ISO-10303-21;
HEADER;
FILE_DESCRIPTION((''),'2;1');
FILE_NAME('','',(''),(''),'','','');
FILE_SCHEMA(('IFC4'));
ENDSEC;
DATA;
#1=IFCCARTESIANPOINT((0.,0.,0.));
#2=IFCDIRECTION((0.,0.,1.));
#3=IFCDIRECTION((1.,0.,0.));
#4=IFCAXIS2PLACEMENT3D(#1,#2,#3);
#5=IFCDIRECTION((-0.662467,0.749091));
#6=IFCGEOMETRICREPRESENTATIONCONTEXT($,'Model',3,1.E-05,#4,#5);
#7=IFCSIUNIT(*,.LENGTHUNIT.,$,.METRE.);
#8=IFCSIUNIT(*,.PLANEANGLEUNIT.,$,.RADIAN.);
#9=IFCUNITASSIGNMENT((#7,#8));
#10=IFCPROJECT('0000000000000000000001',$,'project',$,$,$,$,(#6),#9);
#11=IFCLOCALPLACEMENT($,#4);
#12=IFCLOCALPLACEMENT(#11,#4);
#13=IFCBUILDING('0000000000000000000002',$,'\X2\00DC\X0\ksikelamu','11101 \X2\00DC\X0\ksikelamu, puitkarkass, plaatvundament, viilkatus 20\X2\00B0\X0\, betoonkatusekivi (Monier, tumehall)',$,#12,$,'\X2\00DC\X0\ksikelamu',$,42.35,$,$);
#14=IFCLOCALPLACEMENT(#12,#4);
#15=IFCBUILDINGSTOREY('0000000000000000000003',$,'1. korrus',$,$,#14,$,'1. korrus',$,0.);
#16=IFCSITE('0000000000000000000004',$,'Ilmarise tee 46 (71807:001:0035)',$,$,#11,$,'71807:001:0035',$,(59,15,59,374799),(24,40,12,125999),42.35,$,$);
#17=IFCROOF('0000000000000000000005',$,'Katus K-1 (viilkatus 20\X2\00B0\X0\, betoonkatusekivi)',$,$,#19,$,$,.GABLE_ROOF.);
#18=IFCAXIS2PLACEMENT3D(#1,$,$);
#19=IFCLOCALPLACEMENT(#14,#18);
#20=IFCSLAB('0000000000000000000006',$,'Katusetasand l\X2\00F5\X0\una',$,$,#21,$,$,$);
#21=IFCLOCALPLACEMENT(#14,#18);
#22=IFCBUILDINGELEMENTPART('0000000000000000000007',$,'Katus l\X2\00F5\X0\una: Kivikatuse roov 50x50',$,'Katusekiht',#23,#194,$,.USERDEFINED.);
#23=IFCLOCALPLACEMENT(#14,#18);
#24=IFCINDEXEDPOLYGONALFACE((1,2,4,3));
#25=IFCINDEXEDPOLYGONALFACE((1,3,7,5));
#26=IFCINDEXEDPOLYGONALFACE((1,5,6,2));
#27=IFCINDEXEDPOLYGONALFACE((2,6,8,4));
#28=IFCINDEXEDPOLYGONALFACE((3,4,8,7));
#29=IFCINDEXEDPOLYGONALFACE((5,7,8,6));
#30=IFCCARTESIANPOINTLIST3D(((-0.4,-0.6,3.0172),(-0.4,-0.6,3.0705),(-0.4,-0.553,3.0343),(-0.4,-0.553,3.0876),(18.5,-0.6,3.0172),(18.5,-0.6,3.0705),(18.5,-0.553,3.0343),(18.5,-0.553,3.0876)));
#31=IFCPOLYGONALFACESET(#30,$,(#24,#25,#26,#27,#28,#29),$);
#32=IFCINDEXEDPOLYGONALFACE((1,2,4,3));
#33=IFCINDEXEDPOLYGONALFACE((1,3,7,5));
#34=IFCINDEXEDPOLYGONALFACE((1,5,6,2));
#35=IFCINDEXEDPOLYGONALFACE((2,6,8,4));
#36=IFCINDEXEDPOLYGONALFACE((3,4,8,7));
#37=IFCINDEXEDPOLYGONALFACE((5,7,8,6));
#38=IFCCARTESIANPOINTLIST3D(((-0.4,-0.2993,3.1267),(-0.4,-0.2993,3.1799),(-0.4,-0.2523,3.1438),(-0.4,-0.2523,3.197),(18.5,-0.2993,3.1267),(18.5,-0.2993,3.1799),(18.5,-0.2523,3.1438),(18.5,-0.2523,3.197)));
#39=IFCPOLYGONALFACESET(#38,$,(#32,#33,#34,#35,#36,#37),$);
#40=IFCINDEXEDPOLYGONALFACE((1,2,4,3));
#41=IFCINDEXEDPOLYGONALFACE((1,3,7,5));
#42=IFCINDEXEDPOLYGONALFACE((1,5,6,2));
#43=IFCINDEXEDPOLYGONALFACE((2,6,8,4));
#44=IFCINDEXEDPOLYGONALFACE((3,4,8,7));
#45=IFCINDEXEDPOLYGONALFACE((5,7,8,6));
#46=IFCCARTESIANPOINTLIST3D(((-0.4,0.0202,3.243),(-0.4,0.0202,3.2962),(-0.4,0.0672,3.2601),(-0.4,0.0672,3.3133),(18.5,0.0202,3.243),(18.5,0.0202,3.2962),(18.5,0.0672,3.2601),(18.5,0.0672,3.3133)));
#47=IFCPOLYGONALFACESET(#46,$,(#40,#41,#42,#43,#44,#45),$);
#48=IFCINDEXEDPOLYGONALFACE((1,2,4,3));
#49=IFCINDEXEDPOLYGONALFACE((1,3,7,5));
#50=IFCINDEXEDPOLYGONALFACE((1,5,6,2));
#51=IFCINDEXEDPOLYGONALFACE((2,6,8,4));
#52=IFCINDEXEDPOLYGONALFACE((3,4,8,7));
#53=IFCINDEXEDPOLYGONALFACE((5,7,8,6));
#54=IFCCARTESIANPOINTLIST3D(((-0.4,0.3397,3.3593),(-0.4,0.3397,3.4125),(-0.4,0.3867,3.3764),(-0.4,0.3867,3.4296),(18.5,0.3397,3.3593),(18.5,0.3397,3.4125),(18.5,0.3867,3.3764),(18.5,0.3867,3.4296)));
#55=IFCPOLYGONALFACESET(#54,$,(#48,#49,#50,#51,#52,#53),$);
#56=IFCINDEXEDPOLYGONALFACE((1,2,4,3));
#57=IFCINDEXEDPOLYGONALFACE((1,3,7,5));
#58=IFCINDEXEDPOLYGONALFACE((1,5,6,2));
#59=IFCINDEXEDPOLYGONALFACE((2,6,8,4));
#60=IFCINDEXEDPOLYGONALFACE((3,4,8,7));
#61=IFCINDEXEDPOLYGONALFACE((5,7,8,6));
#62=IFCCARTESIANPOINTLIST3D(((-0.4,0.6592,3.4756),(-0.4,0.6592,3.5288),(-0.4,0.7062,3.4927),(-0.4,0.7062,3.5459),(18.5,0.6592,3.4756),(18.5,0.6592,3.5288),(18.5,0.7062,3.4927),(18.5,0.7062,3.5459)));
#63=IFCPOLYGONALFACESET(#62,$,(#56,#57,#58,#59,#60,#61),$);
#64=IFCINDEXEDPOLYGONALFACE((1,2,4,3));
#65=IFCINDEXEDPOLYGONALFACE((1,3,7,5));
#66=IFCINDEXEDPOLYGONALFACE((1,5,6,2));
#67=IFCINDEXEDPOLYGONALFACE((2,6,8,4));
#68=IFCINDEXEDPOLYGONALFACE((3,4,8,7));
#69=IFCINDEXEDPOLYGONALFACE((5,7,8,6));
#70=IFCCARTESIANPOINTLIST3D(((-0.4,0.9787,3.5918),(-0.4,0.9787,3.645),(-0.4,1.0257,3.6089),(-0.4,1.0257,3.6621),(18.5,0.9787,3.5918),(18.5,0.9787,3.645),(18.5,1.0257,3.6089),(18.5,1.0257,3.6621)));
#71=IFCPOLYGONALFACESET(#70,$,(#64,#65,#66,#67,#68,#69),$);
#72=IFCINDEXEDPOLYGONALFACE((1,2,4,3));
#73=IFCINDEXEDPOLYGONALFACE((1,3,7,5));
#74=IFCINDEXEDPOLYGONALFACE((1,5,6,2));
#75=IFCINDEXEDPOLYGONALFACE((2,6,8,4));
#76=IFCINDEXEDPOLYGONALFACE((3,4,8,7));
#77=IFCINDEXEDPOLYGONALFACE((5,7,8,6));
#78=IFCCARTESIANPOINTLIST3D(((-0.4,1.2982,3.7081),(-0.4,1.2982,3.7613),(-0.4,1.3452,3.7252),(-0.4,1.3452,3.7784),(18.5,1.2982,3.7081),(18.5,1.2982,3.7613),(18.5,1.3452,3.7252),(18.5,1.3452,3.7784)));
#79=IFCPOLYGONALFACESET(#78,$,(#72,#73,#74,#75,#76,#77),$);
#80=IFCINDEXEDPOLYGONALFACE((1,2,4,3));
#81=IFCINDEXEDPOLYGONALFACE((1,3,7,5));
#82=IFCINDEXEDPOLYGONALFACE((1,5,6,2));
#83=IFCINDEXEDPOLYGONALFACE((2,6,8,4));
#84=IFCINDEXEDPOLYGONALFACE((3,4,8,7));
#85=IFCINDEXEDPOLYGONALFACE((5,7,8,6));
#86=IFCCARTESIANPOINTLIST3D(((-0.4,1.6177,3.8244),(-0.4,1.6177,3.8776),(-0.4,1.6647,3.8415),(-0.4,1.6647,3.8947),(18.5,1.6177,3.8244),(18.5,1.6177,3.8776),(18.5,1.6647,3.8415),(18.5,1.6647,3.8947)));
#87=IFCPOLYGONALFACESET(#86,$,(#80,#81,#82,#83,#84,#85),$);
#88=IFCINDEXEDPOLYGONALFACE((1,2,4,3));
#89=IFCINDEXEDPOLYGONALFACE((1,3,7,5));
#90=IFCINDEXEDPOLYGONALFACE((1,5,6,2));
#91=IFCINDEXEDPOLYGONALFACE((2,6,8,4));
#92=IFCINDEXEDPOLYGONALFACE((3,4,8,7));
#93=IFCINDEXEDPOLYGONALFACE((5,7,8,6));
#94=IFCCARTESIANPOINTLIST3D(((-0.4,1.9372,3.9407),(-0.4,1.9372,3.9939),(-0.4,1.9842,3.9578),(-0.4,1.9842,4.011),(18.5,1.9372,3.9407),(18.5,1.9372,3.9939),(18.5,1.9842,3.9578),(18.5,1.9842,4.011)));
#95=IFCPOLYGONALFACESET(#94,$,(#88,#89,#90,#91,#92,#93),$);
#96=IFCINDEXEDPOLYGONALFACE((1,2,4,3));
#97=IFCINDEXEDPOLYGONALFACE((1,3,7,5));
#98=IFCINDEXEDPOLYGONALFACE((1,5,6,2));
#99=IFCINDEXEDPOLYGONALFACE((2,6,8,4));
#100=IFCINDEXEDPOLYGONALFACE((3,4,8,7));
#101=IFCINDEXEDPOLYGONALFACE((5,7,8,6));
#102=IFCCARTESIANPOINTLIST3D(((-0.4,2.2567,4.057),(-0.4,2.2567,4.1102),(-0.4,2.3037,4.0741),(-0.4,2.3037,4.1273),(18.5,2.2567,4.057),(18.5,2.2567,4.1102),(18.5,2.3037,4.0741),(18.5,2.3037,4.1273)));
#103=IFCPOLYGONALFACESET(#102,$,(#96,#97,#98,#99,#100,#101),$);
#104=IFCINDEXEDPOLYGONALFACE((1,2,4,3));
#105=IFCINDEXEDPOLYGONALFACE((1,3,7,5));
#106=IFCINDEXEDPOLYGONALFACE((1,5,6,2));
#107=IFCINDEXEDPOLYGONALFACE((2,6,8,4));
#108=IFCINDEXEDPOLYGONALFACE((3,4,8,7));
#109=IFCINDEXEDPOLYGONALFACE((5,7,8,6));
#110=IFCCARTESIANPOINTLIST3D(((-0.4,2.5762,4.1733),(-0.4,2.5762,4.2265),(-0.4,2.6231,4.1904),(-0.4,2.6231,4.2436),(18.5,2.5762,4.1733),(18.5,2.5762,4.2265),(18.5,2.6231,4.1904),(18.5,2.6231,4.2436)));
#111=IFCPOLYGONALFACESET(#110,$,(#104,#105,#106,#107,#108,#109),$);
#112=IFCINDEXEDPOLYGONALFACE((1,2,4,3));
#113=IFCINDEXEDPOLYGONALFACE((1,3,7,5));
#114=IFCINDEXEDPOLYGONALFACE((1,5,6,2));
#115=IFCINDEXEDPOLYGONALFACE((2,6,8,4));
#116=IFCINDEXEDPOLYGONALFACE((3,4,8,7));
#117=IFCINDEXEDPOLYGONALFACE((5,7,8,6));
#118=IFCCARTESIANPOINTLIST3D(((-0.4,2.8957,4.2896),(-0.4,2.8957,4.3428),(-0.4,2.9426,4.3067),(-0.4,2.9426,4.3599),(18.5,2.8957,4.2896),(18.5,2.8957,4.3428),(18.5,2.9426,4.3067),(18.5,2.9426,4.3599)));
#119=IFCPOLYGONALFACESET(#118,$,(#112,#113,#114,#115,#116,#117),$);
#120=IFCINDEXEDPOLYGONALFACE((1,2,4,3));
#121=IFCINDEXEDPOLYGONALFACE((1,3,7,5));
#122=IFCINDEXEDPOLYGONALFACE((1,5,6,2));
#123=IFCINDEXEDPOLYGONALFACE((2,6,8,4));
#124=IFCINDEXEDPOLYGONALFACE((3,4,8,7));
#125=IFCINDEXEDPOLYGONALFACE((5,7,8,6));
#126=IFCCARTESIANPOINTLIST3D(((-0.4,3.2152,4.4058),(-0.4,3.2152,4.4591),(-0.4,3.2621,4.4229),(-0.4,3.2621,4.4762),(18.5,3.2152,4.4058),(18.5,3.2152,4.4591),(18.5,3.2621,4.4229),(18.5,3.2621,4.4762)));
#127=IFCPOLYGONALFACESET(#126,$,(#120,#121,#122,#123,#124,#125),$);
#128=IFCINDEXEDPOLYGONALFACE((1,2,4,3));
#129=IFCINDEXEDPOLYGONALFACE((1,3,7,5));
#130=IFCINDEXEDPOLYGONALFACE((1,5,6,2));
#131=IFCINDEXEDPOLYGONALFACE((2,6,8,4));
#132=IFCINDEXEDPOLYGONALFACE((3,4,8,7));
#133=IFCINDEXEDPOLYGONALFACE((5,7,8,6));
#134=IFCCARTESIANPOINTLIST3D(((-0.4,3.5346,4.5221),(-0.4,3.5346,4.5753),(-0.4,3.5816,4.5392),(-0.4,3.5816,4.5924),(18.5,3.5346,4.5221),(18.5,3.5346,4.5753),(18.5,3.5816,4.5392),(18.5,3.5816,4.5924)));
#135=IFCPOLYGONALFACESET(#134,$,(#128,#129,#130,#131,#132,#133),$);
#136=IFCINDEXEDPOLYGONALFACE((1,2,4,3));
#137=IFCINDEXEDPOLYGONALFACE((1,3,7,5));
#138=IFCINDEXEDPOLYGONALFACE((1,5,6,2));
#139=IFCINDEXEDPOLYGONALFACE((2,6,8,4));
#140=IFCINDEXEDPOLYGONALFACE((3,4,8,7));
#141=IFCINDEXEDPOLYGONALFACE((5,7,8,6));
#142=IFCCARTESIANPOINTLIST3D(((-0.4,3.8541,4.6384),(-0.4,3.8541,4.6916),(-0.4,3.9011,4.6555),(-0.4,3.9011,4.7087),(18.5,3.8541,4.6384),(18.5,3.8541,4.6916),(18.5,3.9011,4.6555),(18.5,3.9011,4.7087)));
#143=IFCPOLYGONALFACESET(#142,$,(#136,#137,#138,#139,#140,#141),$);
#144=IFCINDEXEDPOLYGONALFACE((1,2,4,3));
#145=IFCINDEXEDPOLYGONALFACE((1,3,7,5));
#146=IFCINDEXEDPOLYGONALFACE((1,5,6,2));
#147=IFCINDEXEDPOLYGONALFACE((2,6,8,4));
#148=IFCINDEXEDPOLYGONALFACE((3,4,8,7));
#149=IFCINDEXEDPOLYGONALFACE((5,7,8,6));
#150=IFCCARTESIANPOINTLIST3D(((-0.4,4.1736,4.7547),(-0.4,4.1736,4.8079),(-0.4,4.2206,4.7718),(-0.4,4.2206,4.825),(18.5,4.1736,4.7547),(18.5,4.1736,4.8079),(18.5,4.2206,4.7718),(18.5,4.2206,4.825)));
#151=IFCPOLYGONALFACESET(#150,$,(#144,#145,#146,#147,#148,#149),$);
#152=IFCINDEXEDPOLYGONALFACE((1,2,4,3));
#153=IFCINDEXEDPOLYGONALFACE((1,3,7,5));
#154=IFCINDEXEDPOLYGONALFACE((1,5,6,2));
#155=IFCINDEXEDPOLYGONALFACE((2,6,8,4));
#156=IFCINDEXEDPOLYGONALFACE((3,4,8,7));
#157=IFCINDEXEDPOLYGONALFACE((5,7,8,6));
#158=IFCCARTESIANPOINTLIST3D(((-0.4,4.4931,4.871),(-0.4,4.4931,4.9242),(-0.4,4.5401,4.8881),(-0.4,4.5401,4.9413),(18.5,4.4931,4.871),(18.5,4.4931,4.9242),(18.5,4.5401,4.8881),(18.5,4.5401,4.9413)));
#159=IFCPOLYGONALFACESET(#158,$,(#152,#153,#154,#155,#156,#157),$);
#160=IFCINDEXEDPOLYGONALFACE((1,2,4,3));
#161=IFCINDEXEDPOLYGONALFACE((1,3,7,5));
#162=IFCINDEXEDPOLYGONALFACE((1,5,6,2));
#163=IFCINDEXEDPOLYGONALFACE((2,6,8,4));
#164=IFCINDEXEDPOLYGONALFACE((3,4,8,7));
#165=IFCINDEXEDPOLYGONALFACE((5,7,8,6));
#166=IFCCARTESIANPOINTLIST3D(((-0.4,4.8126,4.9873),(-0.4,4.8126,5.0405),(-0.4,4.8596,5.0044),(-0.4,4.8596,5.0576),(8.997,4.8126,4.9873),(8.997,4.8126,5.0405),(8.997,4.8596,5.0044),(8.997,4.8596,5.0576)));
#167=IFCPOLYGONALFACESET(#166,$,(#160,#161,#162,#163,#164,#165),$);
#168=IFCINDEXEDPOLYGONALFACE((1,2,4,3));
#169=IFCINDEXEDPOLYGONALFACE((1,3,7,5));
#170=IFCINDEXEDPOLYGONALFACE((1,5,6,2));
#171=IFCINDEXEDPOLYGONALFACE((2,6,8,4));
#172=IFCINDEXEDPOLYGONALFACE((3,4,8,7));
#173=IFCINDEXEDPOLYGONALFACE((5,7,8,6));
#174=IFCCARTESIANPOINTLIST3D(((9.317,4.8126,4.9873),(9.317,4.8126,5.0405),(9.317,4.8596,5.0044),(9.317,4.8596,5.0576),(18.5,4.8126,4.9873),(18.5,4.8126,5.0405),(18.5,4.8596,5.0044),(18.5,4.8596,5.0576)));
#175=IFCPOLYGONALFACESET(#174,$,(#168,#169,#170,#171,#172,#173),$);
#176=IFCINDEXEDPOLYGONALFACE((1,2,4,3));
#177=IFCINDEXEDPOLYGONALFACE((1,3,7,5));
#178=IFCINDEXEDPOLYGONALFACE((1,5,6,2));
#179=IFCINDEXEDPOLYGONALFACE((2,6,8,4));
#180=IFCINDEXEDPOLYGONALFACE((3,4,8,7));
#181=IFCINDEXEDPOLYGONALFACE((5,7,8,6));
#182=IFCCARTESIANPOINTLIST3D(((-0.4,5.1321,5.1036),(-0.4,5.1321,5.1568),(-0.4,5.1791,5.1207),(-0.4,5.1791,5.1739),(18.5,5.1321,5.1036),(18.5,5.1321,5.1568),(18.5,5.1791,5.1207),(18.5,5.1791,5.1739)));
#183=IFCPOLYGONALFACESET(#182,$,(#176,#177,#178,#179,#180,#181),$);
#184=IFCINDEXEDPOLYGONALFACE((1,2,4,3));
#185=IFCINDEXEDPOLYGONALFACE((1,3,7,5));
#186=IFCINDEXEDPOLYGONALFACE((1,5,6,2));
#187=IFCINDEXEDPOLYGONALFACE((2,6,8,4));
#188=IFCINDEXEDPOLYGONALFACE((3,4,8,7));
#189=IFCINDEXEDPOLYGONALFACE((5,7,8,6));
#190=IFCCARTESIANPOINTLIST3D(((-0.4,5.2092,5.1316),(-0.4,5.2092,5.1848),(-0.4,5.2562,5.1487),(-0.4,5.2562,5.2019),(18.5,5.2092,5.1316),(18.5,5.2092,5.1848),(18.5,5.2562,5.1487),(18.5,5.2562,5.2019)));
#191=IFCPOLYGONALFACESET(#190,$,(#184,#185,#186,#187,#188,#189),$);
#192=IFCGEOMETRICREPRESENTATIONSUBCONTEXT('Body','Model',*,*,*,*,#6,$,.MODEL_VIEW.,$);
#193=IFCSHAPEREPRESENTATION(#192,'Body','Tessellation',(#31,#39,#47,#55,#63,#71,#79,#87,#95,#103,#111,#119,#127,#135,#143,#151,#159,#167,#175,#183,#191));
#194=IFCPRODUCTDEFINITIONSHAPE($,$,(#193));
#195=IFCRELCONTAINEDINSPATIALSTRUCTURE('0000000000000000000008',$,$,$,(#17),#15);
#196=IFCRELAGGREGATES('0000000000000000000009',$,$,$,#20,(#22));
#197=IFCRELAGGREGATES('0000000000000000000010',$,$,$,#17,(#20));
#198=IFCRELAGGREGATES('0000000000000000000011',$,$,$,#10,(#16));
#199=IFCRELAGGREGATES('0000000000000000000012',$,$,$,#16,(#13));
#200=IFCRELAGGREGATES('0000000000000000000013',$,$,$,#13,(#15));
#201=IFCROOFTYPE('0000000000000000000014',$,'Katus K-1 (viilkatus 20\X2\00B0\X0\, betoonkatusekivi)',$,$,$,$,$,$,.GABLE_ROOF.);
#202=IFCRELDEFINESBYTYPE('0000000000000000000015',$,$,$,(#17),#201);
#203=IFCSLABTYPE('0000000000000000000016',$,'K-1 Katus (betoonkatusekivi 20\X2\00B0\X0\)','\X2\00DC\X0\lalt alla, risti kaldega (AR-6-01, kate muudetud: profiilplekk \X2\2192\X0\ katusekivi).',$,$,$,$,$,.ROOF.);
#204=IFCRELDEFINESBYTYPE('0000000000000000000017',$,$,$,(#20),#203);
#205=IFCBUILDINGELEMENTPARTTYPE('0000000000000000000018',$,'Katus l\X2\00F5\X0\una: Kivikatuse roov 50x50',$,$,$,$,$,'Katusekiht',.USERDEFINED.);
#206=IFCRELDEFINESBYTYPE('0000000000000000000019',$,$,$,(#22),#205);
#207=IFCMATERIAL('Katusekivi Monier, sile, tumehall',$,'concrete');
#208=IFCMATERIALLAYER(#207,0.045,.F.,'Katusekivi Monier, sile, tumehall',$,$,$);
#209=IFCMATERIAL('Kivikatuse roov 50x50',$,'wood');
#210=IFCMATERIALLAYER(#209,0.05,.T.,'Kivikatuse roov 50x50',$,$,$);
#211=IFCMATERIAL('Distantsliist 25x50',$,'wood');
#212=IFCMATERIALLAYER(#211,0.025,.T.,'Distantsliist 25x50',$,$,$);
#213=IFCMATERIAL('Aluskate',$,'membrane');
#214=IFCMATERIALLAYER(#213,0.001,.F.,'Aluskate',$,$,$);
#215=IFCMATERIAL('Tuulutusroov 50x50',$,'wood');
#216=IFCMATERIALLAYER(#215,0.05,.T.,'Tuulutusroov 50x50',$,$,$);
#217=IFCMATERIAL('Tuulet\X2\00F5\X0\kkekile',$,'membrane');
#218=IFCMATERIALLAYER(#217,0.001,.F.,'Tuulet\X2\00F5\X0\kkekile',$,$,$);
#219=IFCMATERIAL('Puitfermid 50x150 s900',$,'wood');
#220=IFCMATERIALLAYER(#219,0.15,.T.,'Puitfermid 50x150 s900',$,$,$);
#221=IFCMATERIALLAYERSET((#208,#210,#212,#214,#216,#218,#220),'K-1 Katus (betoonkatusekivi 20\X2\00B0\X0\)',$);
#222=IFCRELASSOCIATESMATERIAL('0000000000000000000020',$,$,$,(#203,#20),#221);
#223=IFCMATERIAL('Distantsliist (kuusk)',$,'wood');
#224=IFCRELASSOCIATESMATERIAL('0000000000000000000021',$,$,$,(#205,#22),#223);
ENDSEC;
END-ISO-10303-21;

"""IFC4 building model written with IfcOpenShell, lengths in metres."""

from ifc_helpers import new_model, si_unit, direction, frame, origin_with_axes, place, context, subcontext, project, spatial, indexed_curve, outline, extrude, material, layer, layer_set, layer_usage, type_object, element, aggregate, save


model = new_model("IFC4")

# Units and contexts
model_context = context("Model", 3, precision=1e-05, world=origin_with_axes(), true_north=direction((-0.662467, 0.749091)))
body_context = subcontext(model_context, "Body", "Model", "MODEL_VIEW")
ifc_project = project(units=[si_unit("LENGTHUNIT", "METRE"), si_unit("PLANEANGLEUNIT", "RADIAN")], contexts=[model_context])

# Site, building, storey
site_placement = place(None, origin_with_axes())
site = spatial("IfcSite", under=ifc_project, at=site_placement, Name="Ilmarise tee 46 (71807:001:0035)", LongName="71807:001:0035", RefLatitude=(59, 15, 59, 374799), RefLongitude=(24, 40, 12, 125999), RefElevation=42.35)
building_placement = place(site_placement, origin_with_axes())
building = spatial("IfcBuilding", under=site, at=building_placement, Name="Üksikelamu", Description="11101 Üksikelamu, puitkarkass, plaatvundament, viilkatus 20°, betoonkatusekivi (Monier, tumehall)", LongName="Üksikelamu", ElevationOfRefHeight=42.35)
storey_placement = place(building_placement, origin_with_axes())
storey = spatial("IfcBuildingStorey", under=building, at=storey_placement, Name="1. korrus", LongName="1. korrus", Elevation=0.0)

# Roof
roof_type = type_object("IfcRoofType", Name="Katus K-1 (viilkatus 20°, betoonkatusekivi)", PredefinedType="GABLE_ROOF")
roof_placement = place(storey_placement, origin_with_axes())
roof = element("IfcRoof", 1, at=roof_placement, inside=storey, type_object=roof_type, Name="Katus K-1 (viilkatus 20°, betoonkatusekivi)", PredefinedType="GABLE_ROOF")

# Slab, building element part
ifc_material_1 = material(Name="Katusekivi Monier, sile, tumehall", Category="concrete")
ifc_layer_1 = layer(ifc_material_1, 0.045, ventilated=False, Name="Katusekivi Monier, sile, tumehall")
ifc_material_2 = material(Name="Kivikatuse roov 50x50", Category="wood")
ifc_layer_2 = layer(ifc_material_2, 0.05, ventilated=True, Name="Kivikatuse roov 50x50")
ifc_material_3 = material(Name="Distantsliist 25x50", Category="wood")
ifc_layer_3 = layer(ifc_material_3, 0.025, ventilated=True, Name="Distantsliist 25x50")
ifc_material_4 = material(Name="Aluskate", Category="membrane")
ifc_layer_4 = layer(ifc_material_4, 0.001, ventilated=False, Name="Aluskate")
ifc_material_5 = material(Name="Tuulutusroov 50x50", Category="wood")
ifc_layer_5 = layer(ifc_material_5, 0.05, ventilated=True, Name="Tuulutusroov 50x50")
ifc_material_6 = material(Name="Tuuletõkkekile", Category="membrane")
ifc_layer_6 = layer(ifc_material_6, 0.001, ventilated=False, Name="Tuuletõkkekile")
ifc_material_7 = material(Name="Puitfermid 50x150 s900", Category="wood")
ifc_layer_7 = layer(ifc_material_7, 0.15, ventilated=True, Name="Puitfermid 50x150 s900")
ifc_layer_set = layer_set([ifc_layer_1, ifc_layer_2, ifc_layer_3, ifc_layer_4, ifc_layer_5, ifc_layer_6, ifc_layer_7], Name="K-1 Katus (betoonkatusekivi 20°)")
ifc_layer_usage_1 = layer_usage(ifc_layer_set, "AXIS3", "POSITIVE", 0.0)
slab_type = type_object("IfcSlabType", Name="K-1 Katus (betoonkatusekivi 20°)", Description="Ülalt alla, risti kaldega (AR-6-01, kate muudetud: profiilplekk → katusekivi).", PredefinedType="ROOF", material=ifc_layer_set)
slab_1_placement = place(roof_placement, origin_with_axes())
slab_1 = element("IfcSlab", 2, at=slab_1_placement, type_object=slab_type, material=ifc_layer_usage_1, Name="Katusetasand lõuna")
ifc_material_8 = material(Name="Distantsliist (kuusk)", Category="wood")
building_element_part_type_1 = type_object("IfcBuildingElementPartType", Name="Katus lõuna: Kivikatuse roov 50x50", ElementType="Katusekiht", PredefinedType="USERDEFINED", material=ifc_material_8)
building_element_part_1_placement = place(slab_1_placement, origin_with_axes())
building_element_part_1 = element("IfcBuildingElementPart", 3, at=building_element_part_1_placement, type_object=building_element_part_type_1, material=ifc_material_8, Name="Katus lõuna: Kivikatuse roov 50x50", ObjectType="Katusekiht", PredefinedType="USERDEFINED", context=body_context, shape_type="SweptSolid", body=[
    extrude(outline(indexed_curve([(-0.6, 3.0172), (-0.553, 3.0343), (-0.553, 3.0876), (-0.6, 3.0705), (-0.6, 3.0172)], self_intersect=False)), frame((-0.4, 0.0, 0.0), z_axis=(1.0, 0.0, 0.0), x_axis=(0.0, 1.0, 0.0)), (0.0, 0.0, 1.0), 18.9),
    extrude(outline(indexed_curve([(-0.2993, 3.1267), (-0.2523, 3.1438), (-0.2523, 3.197), (-0.2993, 3.1799), (-0.2993, 3.1267)], self_intersect=False)), frame((-0.4, 0.0, 0.0), z_axis=(1.0, 0.0, 0.0), x_axis=(0.0, 1.0, 0.0)), (0.0, 0.0, 1.0), 18.9),
    extrude(outline(indexed_curve([(0.0202, 3.243), (0.0672, 3.2601), (0.0672, 3.3133), (0.0202, 3.2962), (0.0202, 3.243)], self_intersect=False)), frame((-0.4, 0.0, 0.0), z_axis=(1.0, 0.0, 0.0), x_axis=(0.0, 1.0, 0.0)), (0.0, 0.0, 1.0), 18.9),
    extrude(outline(indexed_curve([(0.3397, 3.3593), (0.3867, 3.3764), (0.3867, 3.4296), (0.3397, 3.4125), (0.3397, 3.3593)], self_intersect=False)), frame((-0.4, 0.0, 0.0), z_axis=(1.0, 0.0, 0.0), x_axis=(0.0, 1.0, 0.0)), (0.0, 0.0, 1.0), 18.9),
    extrude(outline(indexed_curve([(0.6592, 3.4756), (0.7062, 3.4927), (0.7062, 3.5459), (0.6592, 3.5288), (0.6592, 3.4756)], self_intersect=False)), frame((-0.4, 0.0, 0.0), z_axis=(1.0, 0.0, 0.0), x_axis=(0.0, 1.0, 0.0)), (0.0, 0.0, 1.0), 18.9),
    extrude(outline(indexed_curve([(0.9787, 3.5918), (1.0257, 3.6089), (1.0257, 3.6621), (0.9787, 3.645), (0.9787, 3.5918)], self_intersect=False)), frame((-0.4, 0.0, 0.0), z_axis=(1.0, 0.0, 0.0), x_axis=(0.0, 1.0, 0.0)), (0.0, 0.0, 1.0), 18.9),
    extrude(outline(indexed_curve([(1.2982, 3.7081), (1.3452, 3.7252), (1.3452, 3.7784), (1.2982, 3.7613), (1.2982, 3.7081)], self_intersect=False)), frame((-0.4, 0.0, 0.0), z_axis=(1.0, 0.0, 0.0), x_axis=(0.0, 1.0, 0.0)), (0.0, 0.0, 1.0), 18.9),
    extrude(outline(indexed_curve([(1.6177, 3.8244), (1.6647, 3.8415), (1.6647, 3.8947), (1.6177, 3.8776), (1.6177, 3.8244)], self_intersect=False)), frame((-0.4, 0.0, 0.0), z_axis=(1.0, 0.0, 0.0), x_axis=(0.0, 1.0, 0.0)), (0.0, 0.0, 1.0), 18.9),
    extrude(outline(indexed_curve([(1.9372, 3.9407), (1.9842, 3.9578), (1.9842, 4.011), (1.9372, 3.9939), (1.9372, 3.9407)], self_intersect=False)), frame((-0.4, 0.0, 0.0), z_axis=(1.0, 0.0, 0.0), x_axis=(0.0, 1.0, 0.0)), (0.0, 0.0, 1.0), 18.9),
    extrude(outline(indexed_curve([(2.2567, 4.057), (2.3037, 4.0741), (2.3037, 4.1273), (2.2567, 4.1102), (2.2567, 4.057)], self_intersect=False)), frame((-0.4, 0.0, 0.0), z_axis=(1.0, 0.0, 0.0), x_axis=(0.0, 1.0, 0.0)), (0.0, 0.0, 1.0), 18.9),
    extrude(outline(indexed_curve([(2.5762, 4.1733), (2.6231, 4.1904), (2.6231, 4.2436), (2.5762, 4.2265), (2.5762, 4.1733)], self_intersect=False)), frame((-0.4, 0.0, 0.0), z_axis=(1.0, 0.0, 0.0), x_axis=(0.0, 1.0, 0.0)), (0.0, 0.0, 1.0), 18.9),
    extrude(outline(indexed_curve([(2.8957, 4.2896), (2.9426, 4.3067), (2.9426, 4.3599), (2.8957, 4.3428), (2.8957, 4.2896)], self_intersect=False)), frame((-0.4, 0.0, 0.0), z_axis=(1.0, 0.0, 0.0), x_axis=(0.0, 1.0, 0.0)), (0.0, 0.0, 1.0), 18.9),
    extrude(outline(indexed_curve([(3.2152, 4.4058), (3.2621, 4.4229), (3.2621, 4.4762), (3.2152, 4.4591), (3.2152, 4.4058)], self_intersect=False)), frame((-0.4, 0.0, 0.0), z_axis=(1.0, 0.0, 0.0), x_axis=(0.0, 1.0, 0.0)), (0.0, 0.0, 1.0), 18.9),
    extrude(outline(indexed_curve([(3.5346, 4.5221), (3.5816, 4.5392), (3.5816, 4.5924), (3.5346, 4.5753), (3.5346, 4.5221)], self_intersect=False)), frame((-0.4, 0.0, 0.0), z_axis=(1.0, 0.0, 0.0), x_axis=(0.0, 1.0, 0.0)), (0.0, 0.0, 1.0), 18.9),
    extrude(outline(indexed_curve([(3.8541, 4.6384), (3.9011, 4.6555), (3.9011, 4.7087), (3.8541, 4.6916), (3.8541, 4.6384)], self_intersect=False)), frame((-0.4, 0.0, 0.0), z_axis=(1.0, 0.0, 0.0), x_axis=(0.0, 1.0, 0.0)), (0.0, 0.0, 1.0), 18.9),
    extrude(outline(indexed_curve([(4.1736, 4.7547), (4.2206, 4.7718), (4.2206, 4.825), (4.1736, 4.8079), (4.1736, 4.7547)], self_intersect=False)), frame((-0.4, 0.0, 0.0), z_axis=(1.0, 0.0, 0.0), x_axis=(0.0, 1.0, 0.0)), (0.0, 0.0, 1.0), 18.9),
    extrude(outline(indexed_curve([(4.4931, 4.871), (4.5401, 4.8881), (4.5401, 4.9413), (4.4931, 4.9242), (4.4931, 4.871)], self_intersect=False)), frame((-0.4, 0.0, 0.0), z_axis=(1.0, 0.0, 0.0), x_axis=(0.0, 1.0, 0.0)), (0.0, 0.0, 1.0), 18.9),
    extrude(outline(indexed_curve([(4.8126, 4.9873), (4.8596, 5.0044), (4.8596, 5.0576), (4.8126, 5.0405), (4.8126, 4.9873)], self_intersect=False)), frame((-0.4, 0.0, 0.0), z_axis=(1.0, 0.0, 0.0), x_axis=(0.0, 1.0, 0.0)), (0.0, 0.0, 1.0), 9.397),
    extrude(outline(indexed_curve([(4.8126, 4.9873), (4.8596, 5.0044), (4.8596, 5.0576), (4.8126, 5.0405), (4.8126, 4.9873)], self_intersect=False)), frame((9.317, 0.0, 0.0), z_axis=(1.0, 0.0, 0.0), x_axis=(0.0, 1.0, 0.0)), (0.0, 0.0, 1.0), 9.183),
    extrude(outline(indexed_curve([(5.1321, 5.1036), (5.1791, 5.1207), (5.1791, 5.1739), (5.1321, 5.1568), (5.1321, 5.1036)], self_intersect=False)), frame((-0.4, 0.0, 0.0), z_axis=(1.0, 0.0, 0.0), x_axis=(0.0, 1.0, 0.0)), (0.0, 0.0, 1.0), 18.9),
    extrude(outline(indexed_curve([(5.2092, 5.1316), (5.2562, 5.1487), (5.2562, 5.2019), (5.2092, 5.1848), (5.2092, 5.1316)], self_intersect=False)), frame((-0.4, 0.0, 0.0), z_axis=(1.0, 0.0, 0.0), x_axis=(0.0, 1.0, 0.0)), (0.0, 0.0, 1.0), 18.9),
])
aggregate(slab_1, [building_element_part_1])

aggregate(roof, [slab_1])

save(model, "model.ifc")
